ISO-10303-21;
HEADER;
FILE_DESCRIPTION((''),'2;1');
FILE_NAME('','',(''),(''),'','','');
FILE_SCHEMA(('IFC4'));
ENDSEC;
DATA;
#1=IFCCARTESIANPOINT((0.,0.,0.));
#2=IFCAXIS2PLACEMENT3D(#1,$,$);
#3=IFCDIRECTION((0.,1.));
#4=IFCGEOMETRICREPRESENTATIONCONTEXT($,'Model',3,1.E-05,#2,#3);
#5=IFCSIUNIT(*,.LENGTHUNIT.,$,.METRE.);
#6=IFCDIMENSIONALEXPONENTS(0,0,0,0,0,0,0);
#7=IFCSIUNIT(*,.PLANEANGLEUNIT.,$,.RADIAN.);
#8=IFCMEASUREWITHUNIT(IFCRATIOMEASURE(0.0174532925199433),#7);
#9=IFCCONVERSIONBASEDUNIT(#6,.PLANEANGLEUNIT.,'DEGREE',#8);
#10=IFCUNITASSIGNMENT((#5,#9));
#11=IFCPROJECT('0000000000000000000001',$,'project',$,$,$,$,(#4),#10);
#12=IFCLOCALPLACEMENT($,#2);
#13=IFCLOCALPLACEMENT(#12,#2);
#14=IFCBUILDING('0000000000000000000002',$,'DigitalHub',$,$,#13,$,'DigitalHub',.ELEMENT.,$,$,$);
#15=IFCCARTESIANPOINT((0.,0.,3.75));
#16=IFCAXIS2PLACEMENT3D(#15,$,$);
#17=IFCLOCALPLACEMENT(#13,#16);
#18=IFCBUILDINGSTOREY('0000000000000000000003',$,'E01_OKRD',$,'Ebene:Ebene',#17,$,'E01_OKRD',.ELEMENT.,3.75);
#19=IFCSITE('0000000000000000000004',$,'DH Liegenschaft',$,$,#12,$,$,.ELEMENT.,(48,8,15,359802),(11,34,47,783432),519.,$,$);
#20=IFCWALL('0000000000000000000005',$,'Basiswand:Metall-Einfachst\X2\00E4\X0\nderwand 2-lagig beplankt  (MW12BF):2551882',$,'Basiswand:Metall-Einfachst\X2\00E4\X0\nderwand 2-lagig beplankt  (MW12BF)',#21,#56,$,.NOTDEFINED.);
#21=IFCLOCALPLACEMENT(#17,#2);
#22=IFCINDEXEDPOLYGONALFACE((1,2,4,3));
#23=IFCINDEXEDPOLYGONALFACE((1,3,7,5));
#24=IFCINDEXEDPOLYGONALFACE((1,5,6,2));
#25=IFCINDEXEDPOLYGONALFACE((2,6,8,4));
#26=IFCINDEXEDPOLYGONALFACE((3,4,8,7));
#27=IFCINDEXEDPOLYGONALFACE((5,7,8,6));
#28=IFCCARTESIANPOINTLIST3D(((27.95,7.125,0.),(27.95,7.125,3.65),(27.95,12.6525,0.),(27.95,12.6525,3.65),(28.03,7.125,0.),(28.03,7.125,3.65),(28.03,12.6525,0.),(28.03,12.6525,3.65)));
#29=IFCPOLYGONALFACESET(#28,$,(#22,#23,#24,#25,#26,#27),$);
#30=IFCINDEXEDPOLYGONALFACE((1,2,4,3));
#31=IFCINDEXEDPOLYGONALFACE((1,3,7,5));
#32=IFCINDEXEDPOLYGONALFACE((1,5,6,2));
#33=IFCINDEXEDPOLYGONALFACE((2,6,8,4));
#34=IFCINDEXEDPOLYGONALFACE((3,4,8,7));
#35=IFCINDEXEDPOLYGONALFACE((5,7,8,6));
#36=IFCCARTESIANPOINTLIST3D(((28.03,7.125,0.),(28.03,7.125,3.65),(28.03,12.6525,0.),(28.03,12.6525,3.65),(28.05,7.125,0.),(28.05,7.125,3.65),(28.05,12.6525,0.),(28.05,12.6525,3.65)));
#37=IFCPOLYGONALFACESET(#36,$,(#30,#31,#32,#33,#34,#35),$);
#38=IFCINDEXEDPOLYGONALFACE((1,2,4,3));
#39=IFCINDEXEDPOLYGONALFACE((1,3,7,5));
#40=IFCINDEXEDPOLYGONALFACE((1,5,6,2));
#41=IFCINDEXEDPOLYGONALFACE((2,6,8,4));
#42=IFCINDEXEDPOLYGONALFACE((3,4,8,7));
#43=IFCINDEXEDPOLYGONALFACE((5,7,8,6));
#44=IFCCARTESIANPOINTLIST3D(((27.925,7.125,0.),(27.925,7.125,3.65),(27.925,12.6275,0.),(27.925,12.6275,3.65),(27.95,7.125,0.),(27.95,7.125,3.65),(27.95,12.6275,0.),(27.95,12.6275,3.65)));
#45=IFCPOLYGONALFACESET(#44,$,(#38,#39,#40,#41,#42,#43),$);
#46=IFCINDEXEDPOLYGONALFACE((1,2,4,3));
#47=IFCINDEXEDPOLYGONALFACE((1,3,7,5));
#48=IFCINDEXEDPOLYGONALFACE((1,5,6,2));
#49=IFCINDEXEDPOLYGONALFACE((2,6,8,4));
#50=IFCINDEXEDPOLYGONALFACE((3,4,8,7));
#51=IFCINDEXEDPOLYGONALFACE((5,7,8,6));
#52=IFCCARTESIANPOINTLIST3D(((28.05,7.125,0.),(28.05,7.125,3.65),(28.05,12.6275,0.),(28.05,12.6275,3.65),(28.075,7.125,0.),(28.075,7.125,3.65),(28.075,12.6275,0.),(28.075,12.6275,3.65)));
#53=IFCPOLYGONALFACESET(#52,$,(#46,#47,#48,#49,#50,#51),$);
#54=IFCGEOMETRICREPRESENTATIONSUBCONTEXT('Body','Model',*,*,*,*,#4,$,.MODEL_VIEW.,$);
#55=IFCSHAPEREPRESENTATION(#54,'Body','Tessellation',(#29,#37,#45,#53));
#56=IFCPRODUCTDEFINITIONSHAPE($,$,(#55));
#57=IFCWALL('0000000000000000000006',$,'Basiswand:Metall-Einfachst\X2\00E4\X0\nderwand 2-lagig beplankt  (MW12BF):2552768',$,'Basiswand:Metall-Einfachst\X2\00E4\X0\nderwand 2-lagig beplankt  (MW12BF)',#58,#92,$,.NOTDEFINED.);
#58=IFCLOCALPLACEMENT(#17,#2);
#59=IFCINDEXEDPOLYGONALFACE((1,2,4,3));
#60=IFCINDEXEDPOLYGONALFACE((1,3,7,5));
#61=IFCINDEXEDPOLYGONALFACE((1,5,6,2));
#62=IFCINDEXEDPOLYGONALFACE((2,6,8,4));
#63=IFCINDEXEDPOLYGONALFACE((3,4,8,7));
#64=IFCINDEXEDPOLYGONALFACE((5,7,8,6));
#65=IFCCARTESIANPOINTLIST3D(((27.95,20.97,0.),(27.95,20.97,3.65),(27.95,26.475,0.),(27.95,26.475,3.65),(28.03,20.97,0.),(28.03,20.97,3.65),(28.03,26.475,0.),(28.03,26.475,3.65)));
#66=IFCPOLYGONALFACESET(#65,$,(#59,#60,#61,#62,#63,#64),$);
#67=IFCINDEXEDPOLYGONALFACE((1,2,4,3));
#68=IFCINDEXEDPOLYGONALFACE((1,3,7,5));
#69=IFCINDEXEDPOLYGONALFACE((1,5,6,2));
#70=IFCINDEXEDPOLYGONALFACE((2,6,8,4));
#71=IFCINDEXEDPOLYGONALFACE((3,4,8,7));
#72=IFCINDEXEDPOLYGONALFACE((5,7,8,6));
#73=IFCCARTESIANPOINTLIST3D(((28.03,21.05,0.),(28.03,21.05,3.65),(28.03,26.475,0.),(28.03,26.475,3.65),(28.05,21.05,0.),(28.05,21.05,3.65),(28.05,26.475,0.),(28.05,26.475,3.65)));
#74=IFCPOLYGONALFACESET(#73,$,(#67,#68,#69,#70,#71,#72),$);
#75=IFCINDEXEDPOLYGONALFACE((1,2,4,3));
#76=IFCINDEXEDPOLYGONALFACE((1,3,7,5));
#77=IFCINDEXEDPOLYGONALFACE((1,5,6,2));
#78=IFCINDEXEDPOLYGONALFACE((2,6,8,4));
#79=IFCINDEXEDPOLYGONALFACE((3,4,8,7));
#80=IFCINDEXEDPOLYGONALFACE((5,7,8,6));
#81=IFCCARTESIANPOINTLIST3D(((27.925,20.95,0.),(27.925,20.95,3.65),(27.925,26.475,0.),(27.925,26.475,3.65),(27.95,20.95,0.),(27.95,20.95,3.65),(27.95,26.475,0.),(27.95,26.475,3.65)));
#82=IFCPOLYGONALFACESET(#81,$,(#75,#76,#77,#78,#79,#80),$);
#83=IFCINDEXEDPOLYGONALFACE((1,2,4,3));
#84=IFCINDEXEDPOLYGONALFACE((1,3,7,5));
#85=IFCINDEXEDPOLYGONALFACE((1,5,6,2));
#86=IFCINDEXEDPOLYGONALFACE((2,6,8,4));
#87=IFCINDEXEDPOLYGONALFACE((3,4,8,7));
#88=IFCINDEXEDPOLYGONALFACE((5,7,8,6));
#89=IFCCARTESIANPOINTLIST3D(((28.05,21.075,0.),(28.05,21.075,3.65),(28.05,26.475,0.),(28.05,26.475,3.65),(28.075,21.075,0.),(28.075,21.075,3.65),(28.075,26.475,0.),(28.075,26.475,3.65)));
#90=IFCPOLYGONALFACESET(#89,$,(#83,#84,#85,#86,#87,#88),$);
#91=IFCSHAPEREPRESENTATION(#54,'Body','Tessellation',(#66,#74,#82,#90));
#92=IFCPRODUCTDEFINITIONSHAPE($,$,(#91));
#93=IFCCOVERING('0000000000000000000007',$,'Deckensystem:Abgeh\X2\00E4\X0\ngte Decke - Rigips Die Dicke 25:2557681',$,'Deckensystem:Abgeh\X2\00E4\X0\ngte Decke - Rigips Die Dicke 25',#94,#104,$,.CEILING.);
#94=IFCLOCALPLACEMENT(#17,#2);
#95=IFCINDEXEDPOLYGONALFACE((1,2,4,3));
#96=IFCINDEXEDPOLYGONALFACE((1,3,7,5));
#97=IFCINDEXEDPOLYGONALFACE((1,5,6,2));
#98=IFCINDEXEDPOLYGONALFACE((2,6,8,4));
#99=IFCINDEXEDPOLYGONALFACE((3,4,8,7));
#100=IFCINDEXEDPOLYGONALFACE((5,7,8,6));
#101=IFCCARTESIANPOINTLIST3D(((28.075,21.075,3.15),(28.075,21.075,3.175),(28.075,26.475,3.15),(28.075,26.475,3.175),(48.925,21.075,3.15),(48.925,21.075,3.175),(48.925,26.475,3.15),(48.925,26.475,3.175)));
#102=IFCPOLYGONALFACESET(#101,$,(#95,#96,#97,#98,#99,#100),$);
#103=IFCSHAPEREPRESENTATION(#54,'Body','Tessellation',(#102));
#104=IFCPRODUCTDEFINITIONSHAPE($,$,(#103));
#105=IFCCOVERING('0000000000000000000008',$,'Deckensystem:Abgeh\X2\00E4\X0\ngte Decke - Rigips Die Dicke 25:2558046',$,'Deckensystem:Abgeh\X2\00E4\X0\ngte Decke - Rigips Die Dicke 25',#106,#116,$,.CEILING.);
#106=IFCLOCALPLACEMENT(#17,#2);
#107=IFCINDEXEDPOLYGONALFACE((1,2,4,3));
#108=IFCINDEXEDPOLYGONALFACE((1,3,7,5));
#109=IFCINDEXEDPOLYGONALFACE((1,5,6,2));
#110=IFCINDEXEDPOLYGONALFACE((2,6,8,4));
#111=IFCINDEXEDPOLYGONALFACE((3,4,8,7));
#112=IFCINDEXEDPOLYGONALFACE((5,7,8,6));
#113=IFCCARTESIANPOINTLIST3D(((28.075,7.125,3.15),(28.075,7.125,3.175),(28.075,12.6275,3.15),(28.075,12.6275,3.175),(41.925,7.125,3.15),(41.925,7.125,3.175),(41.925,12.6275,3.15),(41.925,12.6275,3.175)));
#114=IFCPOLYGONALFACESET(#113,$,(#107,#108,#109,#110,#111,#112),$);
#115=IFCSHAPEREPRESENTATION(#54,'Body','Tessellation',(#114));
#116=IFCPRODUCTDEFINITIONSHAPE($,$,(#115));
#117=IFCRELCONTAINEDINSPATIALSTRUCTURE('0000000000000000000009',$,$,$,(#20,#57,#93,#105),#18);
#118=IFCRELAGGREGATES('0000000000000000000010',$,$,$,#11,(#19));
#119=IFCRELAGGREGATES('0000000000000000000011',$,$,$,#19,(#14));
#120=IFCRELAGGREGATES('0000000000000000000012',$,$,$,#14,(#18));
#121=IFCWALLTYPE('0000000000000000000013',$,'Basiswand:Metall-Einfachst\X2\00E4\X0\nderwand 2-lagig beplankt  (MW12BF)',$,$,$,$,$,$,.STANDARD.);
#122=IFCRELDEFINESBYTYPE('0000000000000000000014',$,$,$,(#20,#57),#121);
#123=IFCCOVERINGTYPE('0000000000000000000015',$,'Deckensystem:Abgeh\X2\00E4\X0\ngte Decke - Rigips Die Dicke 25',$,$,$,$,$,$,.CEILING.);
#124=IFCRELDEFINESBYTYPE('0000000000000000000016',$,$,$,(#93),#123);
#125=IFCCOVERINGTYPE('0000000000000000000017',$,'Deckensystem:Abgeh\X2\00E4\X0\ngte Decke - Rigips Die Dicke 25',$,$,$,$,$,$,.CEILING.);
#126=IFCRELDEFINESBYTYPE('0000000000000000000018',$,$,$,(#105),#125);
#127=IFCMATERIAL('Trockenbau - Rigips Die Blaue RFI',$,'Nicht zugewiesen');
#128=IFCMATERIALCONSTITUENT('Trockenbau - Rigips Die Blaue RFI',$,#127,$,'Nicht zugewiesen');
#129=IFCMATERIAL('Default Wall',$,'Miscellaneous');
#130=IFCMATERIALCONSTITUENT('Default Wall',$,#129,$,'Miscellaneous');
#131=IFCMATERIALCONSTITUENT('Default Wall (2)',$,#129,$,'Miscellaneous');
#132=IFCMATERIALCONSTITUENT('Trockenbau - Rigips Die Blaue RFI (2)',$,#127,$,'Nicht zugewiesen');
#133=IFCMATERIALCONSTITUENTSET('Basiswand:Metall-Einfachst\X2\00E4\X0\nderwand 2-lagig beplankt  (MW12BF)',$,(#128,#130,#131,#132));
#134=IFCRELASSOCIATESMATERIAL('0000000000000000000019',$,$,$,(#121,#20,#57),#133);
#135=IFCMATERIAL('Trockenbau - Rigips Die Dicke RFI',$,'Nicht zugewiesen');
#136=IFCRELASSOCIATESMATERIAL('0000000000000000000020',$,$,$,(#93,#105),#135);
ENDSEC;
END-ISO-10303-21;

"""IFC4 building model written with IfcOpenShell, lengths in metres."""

from ifc_helpers import new_model, entity, si_unit, converted_unit, direction, frame, origin, place, context, subcontext, project, spatial, indexed_curve, outline, extrude, material, constituent, constituent_set, type_object, element, save


model = new_model("IFC4")

# Units and contexts
model_context = context("Model", 3, precision=1e-05, world=origin(), true_north=direction((0.0, 1.0)))
body_context = subcontext(model_context, "Body", "Model", "MODEL_VIEW")
ifc_project = project(units=[si_unit("LENGTHUNIT", "METRE"), converted_unit("PLANEANGLEUNIT", "DEGREE", entity("IfcRatioMeasure", 0.0174532925199433), si_unit("PLANEANGLEUNIT", "RADIAN"), dimensions=[0, 0, 0, 0, 0, 0, 0])], contexts=[model_context])

# Site, building, storey
site_placement = place(None, frame((0.0, 0.0, 0.0)))
site = spatial("IfcSite", under=ifc_project, at=site_placement, Name="DH Liegenschaft", CompositionType="ELEMENT", RefLatitude=(48, 8, 15, 359802), RefLongitude=(11, 34, 47, 783432), RefElevation=519.0)
building_placement = place(site_placement, origin())
building = spatial("IfcBuilding", under=site, at=building_placement, Name="DigitalHub", LongName="DigitalHub", CompositionType="ELEMENT")
storey_placement = place(building_placement, frame((0.0, 0.0, 3.75)))
storey = spatial("IfcBuildingStorey", under=building, at=storey_placement, Name="E01_OKRD", ObjectType="Ebene:Ebene", LongName="E01_OKRD", CompositionType="ELEMENT", Elevation=3.75)

# Shared definitions
ifc_material_1 = material(Name="Trockenbau - Rigips Die Blaue RFI", Category="Nicht zugewiesen")
ifc_constituent_1 = constituent(ifc_material_1, Name="Trockenbau - Rigips Die Blaue RFI", Category="Nicht zugewiesen")
ifc_material_2 = material(Name="Default Wall", Category="Miscellaneous")
ifc_constituent_2 = constituent(ifc_material_2, Name="Default Wall", Category="Miscellaneous")
ifc_constituent_3 = constituent(ifc_material_2, Name="Default Wall (2)", Category="Miscellaneous")
ifc_constituent_4 = constituent(ifc_material_1, Name="Trockenbau - Rigips Die Blaue RFI (2)", Category="Nicht zugewiesen")
ifc_constituent_set_1 = constituent_set(constituents=[ifc_constituent_1, ifc_constituent_2, ifc_constituent_3, ifc_constituent_4], Name="Basiswand:Metall-Einfachständerwand 2-lagig beplankt  (MW12BF)")
wall_type_1 = type_object("IfcWallType", Name="Basiswand:Metall-Einfachständerwand 2-lagig beplankt  (MW12BF)", PredefinedType="STANDARD", material=ifc_constituent_set_1)

# Walls
wall_1_placement = place(storey_placement, frame((28.0, 7.125, 0.0), z_axis=(0.0, 0.0, 1.0), x_axis=(0.0, 1.0, 0.0)))
element("IfcWall", 1, at=wall_1_placement, inside=storey, type_object=wall_type_1, material=ifc_constituent_set_1, Name="Basiswand:Metall-Einfachständerwand 2-lagig beplankt  (MW12BF):2551882", ObjectType="Basiswand:Metall-Einfachständerwand 2-lagig beplankt  (MW12BF)", PredefinedType="NOTDEFINED", context=body_context, shape_type="SweptSolid", body=[
    extrude(outline(indexed_curve([(-2.7638, -0.04), (2.7638, -0.04), (2.7638, 0.04), (-2.7638, 0.04), (-2.7638, -0.04)], self_intersect=False)), frame((2.7638, 0.01, 0.0)), (0.0, 0.0, 1.0), 3.65),
    extrude(outline(indexed_curve([(-2.7638, -0.01), (2.7638, -0.01), (2.7638, 0.01), (-2.7638, 0.01), (-2.7638, -0.01)], self_intersect=False)), frame((2.7638, -0.04, 0.0)), (0.0, 0.0, 1.0), 3.65),
    extrude(outline(indexed_curve([(-0.0125, -2.7513), (0.0125, -2.7513), (0.0125, 2.7513), (-0.0125, 2.7513), (-0.0125, -2.7513)], self_intersect=False)), frame((2.7513, 0.0625, 0.0), z_axis=(0.0, 0.0, 1.0), x_axis=(0.0, -1.0, 0.0)), (0.0, 0.0, 1.0), 3.65),
    extrude(outline(indexed_curve([(-0.0125, -2.7513), (0.0125, -2.7513), (0.0125, 2.7513), (-0.0125, 2.7513), (-0.0125, -2.7513)], self_intersect=False)), frame((2.7513, -0.0625, 0.0), z_axis=(0.0, 0.0, 1.0), x_axis=(0.0, 1.0, 0.0)), (0.0, 0.0, 1.0), 3.65),
])
wall_2_placement = place(storey_placement, frame((28.0, 20.925, 0.0), z_axis=(0.0, 0.0, 1.0), x_axis=(0.0, 1.0, 0.0)))
element("IfcWall", 2, at=wall_2_placement, inside=storey, type_object=wall_type_1, material=ifc_constituent_set_1, Name="Basiswand:Metall-Einfachständerwand 2-lagig beplankt  (MW12BF):2552768", ObjectType="Basiswand:Metall-Einfachständerwand 2-lagig beplankt  (MW12BF)", PredefinedType="NOTDEFINED", context=body_context, shape_type="SweptSolid", body=[
    extrude(outline(indexed_curve([(-2.7525, -0.04), (2.7525, -0.04), (2.7525, 0.04), (-2.7525, 0.04), (-2.7525, -0.04)], self_intersect=False)), frame((2.7975, 0.01, 0.0)), (0.0, 0.0, 1.0), 3.65),
    extrude(outline(indexed_curve([(-2.7125, -0.01), (2.7125, -0.01), (2.7125, 0.01), (-2.7125, 0.01), (-2.7125, -0.01)], self_intersect=False)), frame((2.8375, -0.04, 0.0)), (0.0, 0.0, 1.0), 3.65),
    extrude(outline(indexed_curve([(-0.0125, -2.7625), (0.0125, -2.7625), (0.0125, 2.7625), (-0.0125, 2.7625), (-0.0125, -2.7625)], self_intersect=False)), frame((2.7875, 0.0625, 0.0), z_axis=(0.0, 0.0, 1.0), x_axis=(0.0, -1.0, 0.0)), (0.0, 0.0, 1.0), 3.65),
    extrude(outline(indexed_curve([(-2.7, -0.0125), (2.7, -0.0125), (2.7, 0.0125), (-2.7, 0.0125), (-2.7, -0.0125)], self_intersect=False)), frame((2.85, -0.0625, 0.0)), (0.0, 0.0, 1.0), 3.65),
])

# Coverings
ifc_material_3 = material(Name="Trockenbau - Rigips Die Dicke RFI", Category="Nicht zugewiesen")
covering_type_1 = type_object("IfcCoveringType", Name="Deckensystem:Abgehängte Decke - Rigips Die Dicke 25", PredefinedType="CEILING")
covering_1_placement = place(storey_placement, frame((28.075, 21.075, 3.15)))
element("IfcCovering", 3, at=covering_1_placement, inside=storey, type_object=covering_type_1, material=ifc_material_3, Name="Deckensystem:Abgehängte Decke - Rigips Die Dicke 25:2557681", ObjectType="Deckensystem:Abgehängte Decke - Rigips Die Dicke 25", PredefinedType="CEILING", context=body_context, shape_type="SweptSolid", body=[
    extrude(outline(indexed_curve([(-10.425, -2.7), (10.425, -2.7), (10.425, 2.7), (-10.425, 2.7), (-10.425, -2.7)], self_intersect=False)), frame((10.425, 2.7, 0.0), z_axis=(0.0, 0.0, 1.0), x_axis=(-1.0, 0.0, 0.0)), (0.0, 0.0, 1.0), 0.025),
])
covering_type_2 = type_object("IfcCoveringType", Name="Deckensystem:Abgehängte Decke - Rigips Die Dicke 25", PredefinedType="CEILING")
covering_2_placement = place(storey_placement, frame((28.075, 7.125, 3.15)))
element("IfcCovering", 4, at=covering_2_placement, inside=storey, type_object=covering_type_2, material=ifc_material_3, Name="Deckensystem:Abgehängte Decke - Rigips Die Dicke 25:2558046", ObjectType="Deckensystem:Abgehängte Decke - Rigips Die Dicke 25", PredefinedType="CEILING", context=body_context, shape_type="SweptSolid", body=[
    extrude(outline(indexed_curve([(-6.925, -2.7512), (6.925, -2.7512), (6.925, 2.7512), (-6.925, 2.7512), (-6.925, -2.7512)], self_intersect=False)), frame((6.925, 2.7512, 0.0), z_axis=(0.0, 0.0, 1.0), x_axis=(-1.0, 0.0, 0.0)), (0.0, 0.0, 1.0), 0.025),
])

save(model, "model.ifc")
